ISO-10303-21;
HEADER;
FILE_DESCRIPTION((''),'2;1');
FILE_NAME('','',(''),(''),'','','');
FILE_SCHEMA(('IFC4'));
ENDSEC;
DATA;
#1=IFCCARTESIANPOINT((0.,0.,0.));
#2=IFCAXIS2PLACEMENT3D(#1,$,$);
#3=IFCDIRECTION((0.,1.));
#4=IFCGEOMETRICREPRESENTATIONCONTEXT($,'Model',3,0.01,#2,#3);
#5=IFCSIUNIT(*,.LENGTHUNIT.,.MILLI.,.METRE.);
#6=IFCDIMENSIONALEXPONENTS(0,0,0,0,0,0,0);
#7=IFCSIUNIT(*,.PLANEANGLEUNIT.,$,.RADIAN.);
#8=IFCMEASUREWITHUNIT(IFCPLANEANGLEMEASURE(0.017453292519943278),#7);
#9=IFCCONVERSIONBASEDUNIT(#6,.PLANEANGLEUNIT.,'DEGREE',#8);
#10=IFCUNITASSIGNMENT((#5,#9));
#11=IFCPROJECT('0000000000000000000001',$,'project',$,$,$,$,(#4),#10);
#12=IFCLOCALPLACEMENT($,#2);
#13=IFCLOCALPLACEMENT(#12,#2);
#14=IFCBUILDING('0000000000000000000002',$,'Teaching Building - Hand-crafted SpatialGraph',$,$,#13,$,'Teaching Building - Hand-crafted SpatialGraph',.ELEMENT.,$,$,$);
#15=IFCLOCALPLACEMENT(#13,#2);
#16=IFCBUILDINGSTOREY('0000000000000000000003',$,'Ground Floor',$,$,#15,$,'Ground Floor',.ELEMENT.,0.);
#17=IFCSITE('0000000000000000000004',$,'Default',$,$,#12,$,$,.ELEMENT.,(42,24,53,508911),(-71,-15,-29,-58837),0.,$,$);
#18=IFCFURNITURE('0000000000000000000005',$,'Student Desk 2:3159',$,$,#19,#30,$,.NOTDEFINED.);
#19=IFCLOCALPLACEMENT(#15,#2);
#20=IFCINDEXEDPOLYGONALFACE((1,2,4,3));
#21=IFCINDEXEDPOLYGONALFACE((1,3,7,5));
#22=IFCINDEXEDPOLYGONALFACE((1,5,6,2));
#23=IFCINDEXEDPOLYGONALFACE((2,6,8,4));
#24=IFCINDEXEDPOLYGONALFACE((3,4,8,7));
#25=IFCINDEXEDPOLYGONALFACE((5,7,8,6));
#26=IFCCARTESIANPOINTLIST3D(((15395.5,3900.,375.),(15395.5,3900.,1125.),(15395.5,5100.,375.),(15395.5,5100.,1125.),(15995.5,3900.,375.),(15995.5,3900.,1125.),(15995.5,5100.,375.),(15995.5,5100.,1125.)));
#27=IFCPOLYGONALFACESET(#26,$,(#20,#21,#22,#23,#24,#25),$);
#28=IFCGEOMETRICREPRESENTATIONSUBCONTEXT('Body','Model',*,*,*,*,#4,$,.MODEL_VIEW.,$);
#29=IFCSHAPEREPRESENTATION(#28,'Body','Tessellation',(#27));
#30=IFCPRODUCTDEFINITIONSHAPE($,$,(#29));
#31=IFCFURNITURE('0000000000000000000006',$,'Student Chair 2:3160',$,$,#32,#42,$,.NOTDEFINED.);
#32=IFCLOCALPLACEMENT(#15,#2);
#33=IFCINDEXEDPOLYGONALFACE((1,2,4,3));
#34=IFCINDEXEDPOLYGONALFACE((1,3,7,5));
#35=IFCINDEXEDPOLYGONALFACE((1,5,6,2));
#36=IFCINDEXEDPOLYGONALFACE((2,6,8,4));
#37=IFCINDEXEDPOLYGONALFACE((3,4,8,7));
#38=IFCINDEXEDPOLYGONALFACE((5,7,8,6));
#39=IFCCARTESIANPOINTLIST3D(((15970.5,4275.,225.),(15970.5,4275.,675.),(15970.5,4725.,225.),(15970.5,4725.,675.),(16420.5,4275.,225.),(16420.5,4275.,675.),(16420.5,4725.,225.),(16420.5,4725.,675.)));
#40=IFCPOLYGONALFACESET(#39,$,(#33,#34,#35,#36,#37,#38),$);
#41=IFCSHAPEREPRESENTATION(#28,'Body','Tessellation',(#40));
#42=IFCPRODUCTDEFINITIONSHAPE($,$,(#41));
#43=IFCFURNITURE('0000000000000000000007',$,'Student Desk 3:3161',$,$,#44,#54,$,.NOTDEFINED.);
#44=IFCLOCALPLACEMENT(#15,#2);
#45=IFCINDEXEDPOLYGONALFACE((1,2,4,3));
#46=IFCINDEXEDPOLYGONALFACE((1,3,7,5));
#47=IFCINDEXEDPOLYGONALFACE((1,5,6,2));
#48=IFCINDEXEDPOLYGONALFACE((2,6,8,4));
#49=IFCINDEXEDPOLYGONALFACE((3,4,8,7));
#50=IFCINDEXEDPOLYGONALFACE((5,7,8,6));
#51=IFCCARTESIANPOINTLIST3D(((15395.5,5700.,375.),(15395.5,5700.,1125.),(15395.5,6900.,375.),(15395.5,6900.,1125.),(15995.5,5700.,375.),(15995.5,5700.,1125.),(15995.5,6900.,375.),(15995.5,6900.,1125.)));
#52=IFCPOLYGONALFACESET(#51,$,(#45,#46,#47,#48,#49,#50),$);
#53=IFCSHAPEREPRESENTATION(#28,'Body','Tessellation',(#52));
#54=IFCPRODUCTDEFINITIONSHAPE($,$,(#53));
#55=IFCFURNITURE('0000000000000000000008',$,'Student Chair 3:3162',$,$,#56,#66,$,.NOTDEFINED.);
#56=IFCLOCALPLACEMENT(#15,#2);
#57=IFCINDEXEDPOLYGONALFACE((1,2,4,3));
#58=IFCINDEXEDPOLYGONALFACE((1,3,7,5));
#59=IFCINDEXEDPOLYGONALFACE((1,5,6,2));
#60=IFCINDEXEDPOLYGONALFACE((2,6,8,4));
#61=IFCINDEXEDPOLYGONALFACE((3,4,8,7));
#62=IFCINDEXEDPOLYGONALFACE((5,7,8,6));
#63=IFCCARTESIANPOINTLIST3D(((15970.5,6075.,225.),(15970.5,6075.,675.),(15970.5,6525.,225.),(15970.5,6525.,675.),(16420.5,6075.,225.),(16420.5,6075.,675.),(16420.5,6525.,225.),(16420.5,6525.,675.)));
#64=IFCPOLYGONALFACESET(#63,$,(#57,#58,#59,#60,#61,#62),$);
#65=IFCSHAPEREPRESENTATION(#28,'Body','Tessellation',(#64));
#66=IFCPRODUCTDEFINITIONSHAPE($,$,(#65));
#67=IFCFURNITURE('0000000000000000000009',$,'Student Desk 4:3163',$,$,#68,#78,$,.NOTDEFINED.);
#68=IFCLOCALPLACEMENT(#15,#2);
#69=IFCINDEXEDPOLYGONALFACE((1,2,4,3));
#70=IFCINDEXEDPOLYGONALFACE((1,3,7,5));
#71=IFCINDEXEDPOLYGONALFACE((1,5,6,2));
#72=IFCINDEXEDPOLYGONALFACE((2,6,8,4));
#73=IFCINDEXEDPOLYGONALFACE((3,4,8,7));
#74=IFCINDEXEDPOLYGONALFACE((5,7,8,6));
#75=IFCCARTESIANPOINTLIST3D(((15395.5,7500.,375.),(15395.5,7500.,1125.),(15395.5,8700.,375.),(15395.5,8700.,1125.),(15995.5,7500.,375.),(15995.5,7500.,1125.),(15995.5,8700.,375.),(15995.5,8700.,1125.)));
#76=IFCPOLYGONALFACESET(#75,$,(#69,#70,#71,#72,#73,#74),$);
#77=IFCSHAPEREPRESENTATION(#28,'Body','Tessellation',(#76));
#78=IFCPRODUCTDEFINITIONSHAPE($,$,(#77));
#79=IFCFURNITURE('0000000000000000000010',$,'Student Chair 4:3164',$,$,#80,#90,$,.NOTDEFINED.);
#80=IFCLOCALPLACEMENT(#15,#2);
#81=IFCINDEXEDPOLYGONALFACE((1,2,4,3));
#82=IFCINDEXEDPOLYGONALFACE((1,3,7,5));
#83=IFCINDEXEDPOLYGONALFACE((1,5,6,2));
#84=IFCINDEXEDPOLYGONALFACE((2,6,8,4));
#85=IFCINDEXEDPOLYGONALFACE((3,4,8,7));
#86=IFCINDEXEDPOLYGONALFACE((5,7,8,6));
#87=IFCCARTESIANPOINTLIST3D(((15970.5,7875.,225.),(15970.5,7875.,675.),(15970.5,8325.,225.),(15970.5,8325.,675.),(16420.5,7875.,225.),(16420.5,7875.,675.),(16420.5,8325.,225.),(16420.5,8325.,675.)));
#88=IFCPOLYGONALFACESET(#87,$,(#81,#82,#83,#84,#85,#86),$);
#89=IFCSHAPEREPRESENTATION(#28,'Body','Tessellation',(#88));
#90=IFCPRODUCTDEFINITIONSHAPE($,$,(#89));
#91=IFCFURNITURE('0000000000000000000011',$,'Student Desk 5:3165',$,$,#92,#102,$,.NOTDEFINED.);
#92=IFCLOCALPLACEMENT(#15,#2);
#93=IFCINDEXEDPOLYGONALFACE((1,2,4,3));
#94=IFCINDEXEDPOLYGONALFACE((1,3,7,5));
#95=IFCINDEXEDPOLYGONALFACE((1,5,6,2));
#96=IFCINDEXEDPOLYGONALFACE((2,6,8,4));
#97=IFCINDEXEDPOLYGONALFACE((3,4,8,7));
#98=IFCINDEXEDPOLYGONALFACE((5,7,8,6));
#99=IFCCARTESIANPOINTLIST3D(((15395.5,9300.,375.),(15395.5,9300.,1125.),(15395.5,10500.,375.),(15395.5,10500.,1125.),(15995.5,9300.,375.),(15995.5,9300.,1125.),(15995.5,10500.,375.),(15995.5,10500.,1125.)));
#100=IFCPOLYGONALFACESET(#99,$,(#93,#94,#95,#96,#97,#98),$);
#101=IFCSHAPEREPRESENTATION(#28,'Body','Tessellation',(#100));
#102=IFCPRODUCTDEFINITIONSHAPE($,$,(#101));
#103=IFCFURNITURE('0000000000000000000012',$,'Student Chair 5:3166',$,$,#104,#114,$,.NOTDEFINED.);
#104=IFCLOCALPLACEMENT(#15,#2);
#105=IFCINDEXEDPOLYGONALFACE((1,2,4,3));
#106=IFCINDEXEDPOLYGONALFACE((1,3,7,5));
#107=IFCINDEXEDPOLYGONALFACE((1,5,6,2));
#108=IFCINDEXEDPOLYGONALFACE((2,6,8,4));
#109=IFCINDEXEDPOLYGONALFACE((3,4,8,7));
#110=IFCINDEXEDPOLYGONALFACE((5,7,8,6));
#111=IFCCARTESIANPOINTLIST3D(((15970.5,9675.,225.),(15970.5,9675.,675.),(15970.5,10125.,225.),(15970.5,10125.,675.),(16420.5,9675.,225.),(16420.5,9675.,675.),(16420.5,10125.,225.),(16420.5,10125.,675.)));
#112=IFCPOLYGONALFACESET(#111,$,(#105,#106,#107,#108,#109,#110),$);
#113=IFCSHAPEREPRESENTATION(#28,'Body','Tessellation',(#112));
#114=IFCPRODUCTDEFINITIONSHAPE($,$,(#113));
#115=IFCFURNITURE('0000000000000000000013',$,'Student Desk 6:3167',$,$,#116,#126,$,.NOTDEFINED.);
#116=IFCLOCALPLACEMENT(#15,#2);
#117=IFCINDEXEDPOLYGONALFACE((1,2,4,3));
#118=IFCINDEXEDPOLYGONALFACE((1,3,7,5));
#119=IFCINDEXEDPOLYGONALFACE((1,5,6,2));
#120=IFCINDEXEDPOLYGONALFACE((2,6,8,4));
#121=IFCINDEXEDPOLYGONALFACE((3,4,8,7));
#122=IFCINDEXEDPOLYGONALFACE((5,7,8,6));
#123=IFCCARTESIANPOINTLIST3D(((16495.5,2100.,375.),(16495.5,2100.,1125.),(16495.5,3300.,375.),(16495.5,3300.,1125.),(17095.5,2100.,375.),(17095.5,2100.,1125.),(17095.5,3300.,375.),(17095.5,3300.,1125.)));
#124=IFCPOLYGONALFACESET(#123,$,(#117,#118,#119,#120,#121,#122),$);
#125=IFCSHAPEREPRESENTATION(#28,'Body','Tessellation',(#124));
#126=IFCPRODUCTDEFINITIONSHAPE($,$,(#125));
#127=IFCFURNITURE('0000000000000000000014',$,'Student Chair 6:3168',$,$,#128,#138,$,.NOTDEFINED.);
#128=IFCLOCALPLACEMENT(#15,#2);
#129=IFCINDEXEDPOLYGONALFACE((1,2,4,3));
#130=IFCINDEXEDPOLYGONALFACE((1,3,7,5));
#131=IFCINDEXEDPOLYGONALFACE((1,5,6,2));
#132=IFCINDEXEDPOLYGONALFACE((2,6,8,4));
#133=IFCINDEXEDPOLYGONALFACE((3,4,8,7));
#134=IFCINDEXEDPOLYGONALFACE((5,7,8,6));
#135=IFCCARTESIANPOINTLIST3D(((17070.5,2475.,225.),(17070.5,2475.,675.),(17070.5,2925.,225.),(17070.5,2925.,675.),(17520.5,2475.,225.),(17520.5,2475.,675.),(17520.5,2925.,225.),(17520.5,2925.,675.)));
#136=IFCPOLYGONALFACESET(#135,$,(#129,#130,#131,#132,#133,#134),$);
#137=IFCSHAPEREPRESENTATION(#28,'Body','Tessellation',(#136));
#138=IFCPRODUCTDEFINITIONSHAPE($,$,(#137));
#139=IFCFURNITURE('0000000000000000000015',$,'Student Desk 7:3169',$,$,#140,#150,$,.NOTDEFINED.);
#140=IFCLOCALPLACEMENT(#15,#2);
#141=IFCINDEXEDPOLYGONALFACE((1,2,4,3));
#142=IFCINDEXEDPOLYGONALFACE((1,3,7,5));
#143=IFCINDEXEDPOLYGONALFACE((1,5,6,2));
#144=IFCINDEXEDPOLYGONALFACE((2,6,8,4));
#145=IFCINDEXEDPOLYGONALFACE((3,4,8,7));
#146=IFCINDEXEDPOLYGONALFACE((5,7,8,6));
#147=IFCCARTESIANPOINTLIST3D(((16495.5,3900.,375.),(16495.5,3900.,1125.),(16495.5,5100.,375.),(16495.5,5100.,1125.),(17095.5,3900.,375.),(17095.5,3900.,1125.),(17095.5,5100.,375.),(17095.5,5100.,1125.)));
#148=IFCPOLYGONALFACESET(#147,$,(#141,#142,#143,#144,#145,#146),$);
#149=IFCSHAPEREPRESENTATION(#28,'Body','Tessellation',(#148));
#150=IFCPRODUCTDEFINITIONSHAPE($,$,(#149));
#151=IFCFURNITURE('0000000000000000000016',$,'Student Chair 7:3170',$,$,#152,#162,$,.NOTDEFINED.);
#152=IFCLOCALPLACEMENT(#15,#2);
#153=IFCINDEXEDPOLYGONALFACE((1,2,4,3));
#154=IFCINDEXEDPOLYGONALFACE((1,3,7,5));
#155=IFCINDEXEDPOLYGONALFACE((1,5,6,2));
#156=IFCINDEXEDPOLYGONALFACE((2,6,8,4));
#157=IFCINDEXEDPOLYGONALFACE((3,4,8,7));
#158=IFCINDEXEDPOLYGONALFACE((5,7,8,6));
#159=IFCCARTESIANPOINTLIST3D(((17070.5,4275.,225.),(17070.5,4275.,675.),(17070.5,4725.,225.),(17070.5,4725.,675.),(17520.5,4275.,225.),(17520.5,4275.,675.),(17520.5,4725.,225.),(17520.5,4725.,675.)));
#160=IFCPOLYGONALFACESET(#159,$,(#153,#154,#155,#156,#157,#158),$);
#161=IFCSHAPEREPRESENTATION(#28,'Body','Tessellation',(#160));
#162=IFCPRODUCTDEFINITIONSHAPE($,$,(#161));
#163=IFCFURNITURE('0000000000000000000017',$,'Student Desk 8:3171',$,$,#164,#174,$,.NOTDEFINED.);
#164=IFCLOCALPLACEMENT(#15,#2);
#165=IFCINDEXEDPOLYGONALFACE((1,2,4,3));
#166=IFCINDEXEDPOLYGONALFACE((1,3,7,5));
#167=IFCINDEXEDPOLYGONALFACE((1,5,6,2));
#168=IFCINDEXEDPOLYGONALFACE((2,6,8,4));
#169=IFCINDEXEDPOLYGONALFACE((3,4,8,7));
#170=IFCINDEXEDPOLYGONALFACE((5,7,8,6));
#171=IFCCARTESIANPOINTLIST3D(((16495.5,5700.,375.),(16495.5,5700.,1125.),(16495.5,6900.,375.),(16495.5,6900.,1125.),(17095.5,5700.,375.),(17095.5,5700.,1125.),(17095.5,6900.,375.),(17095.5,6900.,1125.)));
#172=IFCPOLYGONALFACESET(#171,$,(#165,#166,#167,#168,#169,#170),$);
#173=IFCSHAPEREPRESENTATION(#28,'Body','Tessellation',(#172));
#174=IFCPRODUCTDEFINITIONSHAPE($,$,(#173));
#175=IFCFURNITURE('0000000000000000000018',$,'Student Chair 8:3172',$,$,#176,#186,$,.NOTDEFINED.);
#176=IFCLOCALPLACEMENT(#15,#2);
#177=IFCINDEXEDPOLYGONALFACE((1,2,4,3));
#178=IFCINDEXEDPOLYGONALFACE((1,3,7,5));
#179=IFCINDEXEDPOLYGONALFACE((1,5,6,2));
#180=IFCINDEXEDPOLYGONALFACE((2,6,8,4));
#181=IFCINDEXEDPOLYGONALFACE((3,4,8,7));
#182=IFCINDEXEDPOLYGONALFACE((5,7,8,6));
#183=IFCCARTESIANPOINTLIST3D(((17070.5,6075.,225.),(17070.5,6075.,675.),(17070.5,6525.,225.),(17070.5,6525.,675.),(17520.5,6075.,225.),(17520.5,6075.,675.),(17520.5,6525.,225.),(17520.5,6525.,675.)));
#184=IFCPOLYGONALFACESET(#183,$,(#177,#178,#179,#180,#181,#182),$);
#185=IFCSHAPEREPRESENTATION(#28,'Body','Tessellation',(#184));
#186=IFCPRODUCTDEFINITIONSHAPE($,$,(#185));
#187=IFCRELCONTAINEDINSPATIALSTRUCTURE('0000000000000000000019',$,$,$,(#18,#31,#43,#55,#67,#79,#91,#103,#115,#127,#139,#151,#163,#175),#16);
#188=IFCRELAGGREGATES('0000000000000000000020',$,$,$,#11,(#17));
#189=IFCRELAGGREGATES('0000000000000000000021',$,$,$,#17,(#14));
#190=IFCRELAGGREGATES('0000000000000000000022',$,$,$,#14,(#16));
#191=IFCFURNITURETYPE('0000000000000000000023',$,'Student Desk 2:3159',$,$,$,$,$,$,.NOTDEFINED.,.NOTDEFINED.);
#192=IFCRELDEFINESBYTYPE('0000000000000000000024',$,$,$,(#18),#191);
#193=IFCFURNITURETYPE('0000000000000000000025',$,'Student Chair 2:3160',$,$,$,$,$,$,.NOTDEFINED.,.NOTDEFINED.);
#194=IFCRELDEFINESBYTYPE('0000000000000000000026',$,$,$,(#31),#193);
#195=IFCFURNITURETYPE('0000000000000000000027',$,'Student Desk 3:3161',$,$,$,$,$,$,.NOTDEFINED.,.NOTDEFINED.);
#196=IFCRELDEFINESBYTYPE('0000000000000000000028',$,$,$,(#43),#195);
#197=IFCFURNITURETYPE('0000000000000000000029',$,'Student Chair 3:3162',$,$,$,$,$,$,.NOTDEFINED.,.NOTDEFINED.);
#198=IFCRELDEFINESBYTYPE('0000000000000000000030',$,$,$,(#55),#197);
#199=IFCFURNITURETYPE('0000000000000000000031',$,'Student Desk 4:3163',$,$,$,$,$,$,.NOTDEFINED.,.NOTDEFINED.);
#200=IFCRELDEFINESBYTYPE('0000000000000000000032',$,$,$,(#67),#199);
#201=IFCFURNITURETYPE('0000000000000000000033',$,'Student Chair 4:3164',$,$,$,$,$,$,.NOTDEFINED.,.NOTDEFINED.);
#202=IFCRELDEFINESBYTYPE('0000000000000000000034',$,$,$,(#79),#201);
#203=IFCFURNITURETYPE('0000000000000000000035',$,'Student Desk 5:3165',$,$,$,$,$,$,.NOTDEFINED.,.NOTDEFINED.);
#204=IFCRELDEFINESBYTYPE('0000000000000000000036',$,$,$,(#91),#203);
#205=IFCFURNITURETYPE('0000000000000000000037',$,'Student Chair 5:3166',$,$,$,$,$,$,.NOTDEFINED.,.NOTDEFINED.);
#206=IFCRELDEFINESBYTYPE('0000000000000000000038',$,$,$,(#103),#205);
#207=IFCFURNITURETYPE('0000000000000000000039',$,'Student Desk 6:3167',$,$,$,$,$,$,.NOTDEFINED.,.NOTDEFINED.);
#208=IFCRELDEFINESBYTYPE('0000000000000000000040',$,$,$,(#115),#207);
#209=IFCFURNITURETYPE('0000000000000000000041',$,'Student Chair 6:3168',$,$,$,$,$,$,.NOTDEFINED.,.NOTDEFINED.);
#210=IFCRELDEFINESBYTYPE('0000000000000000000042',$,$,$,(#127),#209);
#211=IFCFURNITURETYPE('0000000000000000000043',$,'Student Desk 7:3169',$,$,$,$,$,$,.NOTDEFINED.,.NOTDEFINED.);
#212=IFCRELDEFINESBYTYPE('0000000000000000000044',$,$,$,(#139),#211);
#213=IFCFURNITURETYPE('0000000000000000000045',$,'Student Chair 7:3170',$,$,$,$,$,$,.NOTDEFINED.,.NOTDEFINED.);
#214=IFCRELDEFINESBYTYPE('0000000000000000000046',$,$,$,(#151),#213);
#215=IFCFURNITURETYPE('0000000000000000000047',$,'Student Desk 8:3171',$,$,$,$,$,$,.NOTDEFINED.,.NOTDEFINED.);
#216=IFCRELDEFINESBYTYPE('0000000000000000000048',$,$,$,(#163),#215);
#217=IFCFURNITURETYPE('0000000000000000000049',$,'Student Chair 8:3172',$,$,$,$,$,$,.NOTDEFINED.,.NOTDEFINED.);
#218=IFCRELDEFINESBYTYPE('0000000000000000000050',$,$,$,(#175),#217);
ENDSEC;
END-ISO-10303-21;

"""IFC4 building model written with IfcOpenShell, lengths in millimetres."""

from ifc_helpers import new_model, entity, si_unit, converted_unit, direction, frame, frame_2d, origin, origin_2d_with_axis, place, context, subcontext, project, spatial, rectangle, extrude, type_object, element, save


model = new_model("IFC4")

# Units and contexts
model_context = context("Model", 3, precision=0.01, world=origin(), true_north=direction((0.0, 1.0)))
body_context = subcontext(model_context, "Body", "Model", "MODEL_VIEW")
ifc_project = project(units=[si_unit("LENGTHUNIT", "METRE", prefix="MILLI"), converted_unit("PLANEANGLEUNIT", "DEGREE", entity("IfcPlaneAngleMeasure", 0.017453292519943278), si_unit("PLANEANGLEUNIT", "RADIAN"), dimensions=[0, 0, 0, 0, 0, 0, 0])], contexts=[model_context])

# Site, building, storey
site_placement = place(None, origin())
site = spatial("IfcSite", under=ifc_project, at=site_placement, Name="Default", CompositionType="ELEMENT", RefLatitude=(42, 24, 53, 508911), RefLongitude=(-71, -15, -29, -58837), RefElevation=0.0)
building_placement = place(site_placement, origin())
building = spatial("IfcBuilding", under=site, at=building_placement, Name="Teaching Building - Hand-crafted SpatialGraph", LongName="Teaching Building - Hand-crafted SpatialGraph", CompositionType="ELEMENT")
storey_placement = place(building_placement, origin())
storey = spatial("IfcBuildingStorey", under=building, at=storey_placement, Name="Ground Floor", LongName="Ground Floor", CompositionType="ELEMENT", Elevation=0.0)

# Furniture
furniture_type_1 = type_object("IfcFurnitureType", Name="Student Desk 2:3159", PredefinedType="NOTDEFINED")
furniture_1_placement = place(storey_placement, origin())
element("IfcFurniture", 1, at=furniture_1_placement, inside=storey, type_object=furniture_type_1, Name="Student Desk 2:3159", PredefinedType="NOTDEFINED", context=body_context, shape_type="SweptSolid", body=[
    extrude(rectangle(XDim=1200.0, YDim=600.0, at=frame_2d((0.0, 0.0), x_axis=(1.0, 0.0))), frame((15695.5, 4500.0, 375.0), z_axis=(0.0, 0.0, 1.0), x_axis=(0.0, 1.0, 0.0)), (0.0, 0.0, 1.0), 750.0),
])
furniture_type_2 = type_object("IfcFurnitureType", Name="Student Chair 2:3160", PredefinedType="NOTDEFINED")
furniture_2_placement = place(storey_placement, origin())
element("IfcFurniture", 2, at=furniture_2_placement, inside=storey, type_object=furniture_type_2, Name="Student Chair 2:3160", PredefinedType="NOTDEFINED", context=body_context, shape_type="SweptSolid", body=[
    extrude(rectangle(XDim=450.0, YDim=450.0, at=origin_2d_with_axis()), frame((16195.5, 4500.0, 225.0)), (0.0, 0.0, 1.0), 450.0),
])
furniture_type_3 = type_object("IfcFurnitureType", Name="Student Desk 3:3161", PredefinedType="NOTDEFINED")
furniture_3_placement = place(storey_placement, origin())
element("IfcFurniture", 3, at=furniture_3_placement, inside=storey, type_object=furniture_type_3, Name="Student Desk 3:3161", PredefinedType="NOTDEFINED", context=body_context, shape_type="SweptSolid", body=[
    extrude(rectangle(XDim=1200.0, YDim=600.0, at=origin_2d_with_axis()), frame((15695.5, 6300.0, 375.0), z_axis=(0.0, 0.0, 1.0), x_axis=(0.0, 1.0, 0.0)), (0.0, 0.0, 1.0), 750.0),
])
furniture_type_4 = type_object("IfcFurnitureType", Name="Student Chair 3:3162", PredefinedType="NOTDEFINED")
furniture_4_placement = place(storey_placement, origin())
element("IfcFurniture", 4, at=furniture_4_placement, inside=storey, type_object=furniture_type_4, Name="Student Chair 3:3162", PredefinedType="NOTDEFINED", context=body_context, shape_type="SweptSolid", body=[
    extrude(rectangle(XDim=450.0, YDim=450.0, at=origin_2d_with_axis()), frame((16195.5, 6300.0, 225.0)), (0.0, 0.0, 1.0), 450.0),
])
furniture_type_5 = type_object("IfcFurnitureType", Name="Student Desk 4:3163", PredefinedType="NOTDEFINED")
furniture_5_placement = place(storey_placement, origin())
element("IfcFurniture", 5, at=furniture_5_placement, inside=storey, type_object=furniture_type_5, Name="Student Desk 4:3163", PredefinedType="NOTDEFINED", context=body_context, shape_type="SweptSolid", body=[
    extrude(rectangle(XDim=1200.0, YDim=600.0, at=origin_2d_with_axis()), frame((15695.5, 8100.0, 375.0), z_axis=(0.0, 0.0, 1.0), x_axis=(0.0, 1.0, 0.0)), (0.0, 0.0, 1.0), 750.0),
])
furniture_type_6 = type_object("IfcFurnitureType", Name="Student Chair 4:3164", PredefinedType="NOTDEFINED")
furniture_6_placement = place(storey_placement, origin())
element("IfcFurniture", 6, at=furniture_6_placement, inside=storey, type_object=furniture_type_6, Name="Student Chair 4:3164", PredefinedType="NOTDEFINED", context=body_context, shape_type="SweptSolid", body=[
    extrude(rectangle(XDim=450.0, YDim=450.0, at=origin_2d_with_axis()), frame((16195.5, 8100.0, 225.0)), (0.0, 0.0, 1.0), 450.0),
])
furniture_type_7 = type_object("IfcFurnitureType", Name="Student Desk 5:3165", PredefinedType="NOTDEFINED")
furniture_7_placement = place(storey_placement, origin())
element("IfcFurniture", 7, at=furniture_7_placement, inside=storey, type_object=furniture_type_7, Name="Student Desk 5:3165", PredefinedType="NOTDEFINED", context=body_context, shape_type="SweptSolid", body=[
    extrude(rectangle(XDim=1200.0, YDim=600.0, at=origin_2d_with_axis()), frame((15695.5, 9900.0, 375.0), z_axis=(0.0, 0.0, 1.0), x_axis=(0.0, 1.0, 0.0)), (0.0, 0.0, 1.0), 750.0),
])
furniture_type_8 = type_object("IfcFurnitureType", Name="Student Chair 5:3166", PredefinedType="NOTDEFINED")
furniture_8_placement = place(storey_placement, origin())
element("IfcFurniture", 8, at=furniture_8_placement, inside=storey, type_object=furniture_type_8, Name="Student Chair 5:3166", PredefinedType="NOTDEFINED", context=body_context, shape_type="SweptSolid", body=[
    extrude(rectangle(XDim=450.0, YDim=450.0, at=frame_2d((0.0, 0.0), x_axis=(1.0, 0.0))), frame((16195.5, 9900.0, 225.0)), (0.0, 0.0, 1.0), 450.0),
])
furniture_type_9 = type_object("IfcFurnitureType", Name="Student Desk 6:3167", PredefinedType="NOTDEFINED")
furniture_9_placement = place(storey_placement, origin())
element("IfcFurniture", 9, at=furniture_9_placement, inside=storey, type_object=furniture_type_9, Name="Student Desk 6:3167", PredefinedType="NOTDEFINED", context=body_context, shape_type="SweptSolid", body=[
    extrude(rectangle(XDim=1200.0, YDim=600.0, at=origin_2d_with_axis()), frame((16795.5, 2700.0, 375.0), z_axis=(0.0, 0.0, 1.0), x_axis=(0.0, 1.0, 0.0)), (0.0, 0.0, 1.0), 750.0),
])
furniture_type_10 = type_object("IfcFurnitureType", Name="Student Chair 6:3168", PredefinedType="NOTDEFINED")
furniture_10_placement = place(storey_placement, origin())
element("IfcFurniture", 10, at=furniture_10_placement, inside=storey, type_object=furniture_type_10, Name="Student Chair 6:3168", PredefinedType="NOTDEFINED", context=body_context, shape_type="SweptSolid", body=[
    extrude(rectangle(XDim=450.0, YDim=450.0, at=origin_2d_with_axis()), frame((17295.5, 2700.0, 225.0)), (0.0, 0.0, 1.0), 450.0),
])
furniture_type_11 = type_object("IfcFurnitureType", Name="Student Desk 7:3169", PredefinedType="NOTDEFINED")
furniture_11_placement = place(storey_placement, origin())
element("IfcFurniture", 11, at=furniture_11_placement, inside=storey, type_object=furniture_type_11, Name="Student Desk 7:3169", PredefinedType="NOTDEFINED", context=body_context, shape_type="SweptSolid", body=[
    extrude(rectangle(XDim=1200.0, YDim=600.0, at=frame_2d((0.0, 0.0), x_axis=(1.0, 0.0))), frame((16795.5, 4500.0, 375.0), z_axis=(0.0, 0.0, 1.0), x_axis=(0.0, 1.0, 0.0)), (0.0, 0.0, 1.0), 750.0),
])
furniture_type_12 = type_object("IfcFurnitureType", Name="Student Chair 7:3170", PredefinedType="NOTDEFINED")
furniture_12_placement = place(storey_placement, origin())
element("IfcFurniture", 12, at=furniture_12_placement, inside=storey, type_object=furniture_type_12, Name="Student Chair 7:3170", PredefinedType="NOTDEFINED", context=body_context, shape_type="SweptSolid", body=[
    extrude(rectangle(XDim=450.0, YDim=450.0, at=origin_2d_with_axis()), frame((17295.5, 4500.0, 225.0)), (0.0, 0.0, 1.0), 450.0),
])
furniture_type_13 = type_object("IfcFurnitureType", Name="Student Desk 8:3171", PredefinedType="NOTDEFINED")
furniture_13_placement = place(storey_placement, origin())
element("IfcFurniture", 13, at=furniture_13_placement, inside=storey, type_object=furniture_type_13, Name="Student Desk 8:3171", PredefinedType="NOTDEFINED", context=body_context, shape_type="SweptSolid", body=[
    extrude(rectangle(XDim=1200.0, YDim=600.0, at=origin_2d_with_axis()), frame((16795.5, 6300.0, 375.0), z_axis=(0.0, 0.0, 1.0), x_axis=(0.0, 1.0, 0.0)), (0.0, 0.0, 1.0), 750.0),
])
furniture_type_14 = type_object("IfcFurnitureType", Name="Student Chair 8:3172", PredefinedType="NOTDEFINED")
furniture_14_placement = place(storey_placement, origin())
element("IfcFurniture", 14, at=furniture_14_placement, inside=storey, type_object=furniture_type_14, Name="Student Chair 8:3172", PredefinedType="NOTDEFINED", context=body_context, shape_type="SweptSolid", body=[
    extrude(rectangle(XDim=450.0, YDim=450.0, at=origin_2d_with_axis()), frame((17295.5, 6300.0, 225.0)), (0.0, 0.0, 1.0), 450.0),
])

save(model, "model.ifc")
